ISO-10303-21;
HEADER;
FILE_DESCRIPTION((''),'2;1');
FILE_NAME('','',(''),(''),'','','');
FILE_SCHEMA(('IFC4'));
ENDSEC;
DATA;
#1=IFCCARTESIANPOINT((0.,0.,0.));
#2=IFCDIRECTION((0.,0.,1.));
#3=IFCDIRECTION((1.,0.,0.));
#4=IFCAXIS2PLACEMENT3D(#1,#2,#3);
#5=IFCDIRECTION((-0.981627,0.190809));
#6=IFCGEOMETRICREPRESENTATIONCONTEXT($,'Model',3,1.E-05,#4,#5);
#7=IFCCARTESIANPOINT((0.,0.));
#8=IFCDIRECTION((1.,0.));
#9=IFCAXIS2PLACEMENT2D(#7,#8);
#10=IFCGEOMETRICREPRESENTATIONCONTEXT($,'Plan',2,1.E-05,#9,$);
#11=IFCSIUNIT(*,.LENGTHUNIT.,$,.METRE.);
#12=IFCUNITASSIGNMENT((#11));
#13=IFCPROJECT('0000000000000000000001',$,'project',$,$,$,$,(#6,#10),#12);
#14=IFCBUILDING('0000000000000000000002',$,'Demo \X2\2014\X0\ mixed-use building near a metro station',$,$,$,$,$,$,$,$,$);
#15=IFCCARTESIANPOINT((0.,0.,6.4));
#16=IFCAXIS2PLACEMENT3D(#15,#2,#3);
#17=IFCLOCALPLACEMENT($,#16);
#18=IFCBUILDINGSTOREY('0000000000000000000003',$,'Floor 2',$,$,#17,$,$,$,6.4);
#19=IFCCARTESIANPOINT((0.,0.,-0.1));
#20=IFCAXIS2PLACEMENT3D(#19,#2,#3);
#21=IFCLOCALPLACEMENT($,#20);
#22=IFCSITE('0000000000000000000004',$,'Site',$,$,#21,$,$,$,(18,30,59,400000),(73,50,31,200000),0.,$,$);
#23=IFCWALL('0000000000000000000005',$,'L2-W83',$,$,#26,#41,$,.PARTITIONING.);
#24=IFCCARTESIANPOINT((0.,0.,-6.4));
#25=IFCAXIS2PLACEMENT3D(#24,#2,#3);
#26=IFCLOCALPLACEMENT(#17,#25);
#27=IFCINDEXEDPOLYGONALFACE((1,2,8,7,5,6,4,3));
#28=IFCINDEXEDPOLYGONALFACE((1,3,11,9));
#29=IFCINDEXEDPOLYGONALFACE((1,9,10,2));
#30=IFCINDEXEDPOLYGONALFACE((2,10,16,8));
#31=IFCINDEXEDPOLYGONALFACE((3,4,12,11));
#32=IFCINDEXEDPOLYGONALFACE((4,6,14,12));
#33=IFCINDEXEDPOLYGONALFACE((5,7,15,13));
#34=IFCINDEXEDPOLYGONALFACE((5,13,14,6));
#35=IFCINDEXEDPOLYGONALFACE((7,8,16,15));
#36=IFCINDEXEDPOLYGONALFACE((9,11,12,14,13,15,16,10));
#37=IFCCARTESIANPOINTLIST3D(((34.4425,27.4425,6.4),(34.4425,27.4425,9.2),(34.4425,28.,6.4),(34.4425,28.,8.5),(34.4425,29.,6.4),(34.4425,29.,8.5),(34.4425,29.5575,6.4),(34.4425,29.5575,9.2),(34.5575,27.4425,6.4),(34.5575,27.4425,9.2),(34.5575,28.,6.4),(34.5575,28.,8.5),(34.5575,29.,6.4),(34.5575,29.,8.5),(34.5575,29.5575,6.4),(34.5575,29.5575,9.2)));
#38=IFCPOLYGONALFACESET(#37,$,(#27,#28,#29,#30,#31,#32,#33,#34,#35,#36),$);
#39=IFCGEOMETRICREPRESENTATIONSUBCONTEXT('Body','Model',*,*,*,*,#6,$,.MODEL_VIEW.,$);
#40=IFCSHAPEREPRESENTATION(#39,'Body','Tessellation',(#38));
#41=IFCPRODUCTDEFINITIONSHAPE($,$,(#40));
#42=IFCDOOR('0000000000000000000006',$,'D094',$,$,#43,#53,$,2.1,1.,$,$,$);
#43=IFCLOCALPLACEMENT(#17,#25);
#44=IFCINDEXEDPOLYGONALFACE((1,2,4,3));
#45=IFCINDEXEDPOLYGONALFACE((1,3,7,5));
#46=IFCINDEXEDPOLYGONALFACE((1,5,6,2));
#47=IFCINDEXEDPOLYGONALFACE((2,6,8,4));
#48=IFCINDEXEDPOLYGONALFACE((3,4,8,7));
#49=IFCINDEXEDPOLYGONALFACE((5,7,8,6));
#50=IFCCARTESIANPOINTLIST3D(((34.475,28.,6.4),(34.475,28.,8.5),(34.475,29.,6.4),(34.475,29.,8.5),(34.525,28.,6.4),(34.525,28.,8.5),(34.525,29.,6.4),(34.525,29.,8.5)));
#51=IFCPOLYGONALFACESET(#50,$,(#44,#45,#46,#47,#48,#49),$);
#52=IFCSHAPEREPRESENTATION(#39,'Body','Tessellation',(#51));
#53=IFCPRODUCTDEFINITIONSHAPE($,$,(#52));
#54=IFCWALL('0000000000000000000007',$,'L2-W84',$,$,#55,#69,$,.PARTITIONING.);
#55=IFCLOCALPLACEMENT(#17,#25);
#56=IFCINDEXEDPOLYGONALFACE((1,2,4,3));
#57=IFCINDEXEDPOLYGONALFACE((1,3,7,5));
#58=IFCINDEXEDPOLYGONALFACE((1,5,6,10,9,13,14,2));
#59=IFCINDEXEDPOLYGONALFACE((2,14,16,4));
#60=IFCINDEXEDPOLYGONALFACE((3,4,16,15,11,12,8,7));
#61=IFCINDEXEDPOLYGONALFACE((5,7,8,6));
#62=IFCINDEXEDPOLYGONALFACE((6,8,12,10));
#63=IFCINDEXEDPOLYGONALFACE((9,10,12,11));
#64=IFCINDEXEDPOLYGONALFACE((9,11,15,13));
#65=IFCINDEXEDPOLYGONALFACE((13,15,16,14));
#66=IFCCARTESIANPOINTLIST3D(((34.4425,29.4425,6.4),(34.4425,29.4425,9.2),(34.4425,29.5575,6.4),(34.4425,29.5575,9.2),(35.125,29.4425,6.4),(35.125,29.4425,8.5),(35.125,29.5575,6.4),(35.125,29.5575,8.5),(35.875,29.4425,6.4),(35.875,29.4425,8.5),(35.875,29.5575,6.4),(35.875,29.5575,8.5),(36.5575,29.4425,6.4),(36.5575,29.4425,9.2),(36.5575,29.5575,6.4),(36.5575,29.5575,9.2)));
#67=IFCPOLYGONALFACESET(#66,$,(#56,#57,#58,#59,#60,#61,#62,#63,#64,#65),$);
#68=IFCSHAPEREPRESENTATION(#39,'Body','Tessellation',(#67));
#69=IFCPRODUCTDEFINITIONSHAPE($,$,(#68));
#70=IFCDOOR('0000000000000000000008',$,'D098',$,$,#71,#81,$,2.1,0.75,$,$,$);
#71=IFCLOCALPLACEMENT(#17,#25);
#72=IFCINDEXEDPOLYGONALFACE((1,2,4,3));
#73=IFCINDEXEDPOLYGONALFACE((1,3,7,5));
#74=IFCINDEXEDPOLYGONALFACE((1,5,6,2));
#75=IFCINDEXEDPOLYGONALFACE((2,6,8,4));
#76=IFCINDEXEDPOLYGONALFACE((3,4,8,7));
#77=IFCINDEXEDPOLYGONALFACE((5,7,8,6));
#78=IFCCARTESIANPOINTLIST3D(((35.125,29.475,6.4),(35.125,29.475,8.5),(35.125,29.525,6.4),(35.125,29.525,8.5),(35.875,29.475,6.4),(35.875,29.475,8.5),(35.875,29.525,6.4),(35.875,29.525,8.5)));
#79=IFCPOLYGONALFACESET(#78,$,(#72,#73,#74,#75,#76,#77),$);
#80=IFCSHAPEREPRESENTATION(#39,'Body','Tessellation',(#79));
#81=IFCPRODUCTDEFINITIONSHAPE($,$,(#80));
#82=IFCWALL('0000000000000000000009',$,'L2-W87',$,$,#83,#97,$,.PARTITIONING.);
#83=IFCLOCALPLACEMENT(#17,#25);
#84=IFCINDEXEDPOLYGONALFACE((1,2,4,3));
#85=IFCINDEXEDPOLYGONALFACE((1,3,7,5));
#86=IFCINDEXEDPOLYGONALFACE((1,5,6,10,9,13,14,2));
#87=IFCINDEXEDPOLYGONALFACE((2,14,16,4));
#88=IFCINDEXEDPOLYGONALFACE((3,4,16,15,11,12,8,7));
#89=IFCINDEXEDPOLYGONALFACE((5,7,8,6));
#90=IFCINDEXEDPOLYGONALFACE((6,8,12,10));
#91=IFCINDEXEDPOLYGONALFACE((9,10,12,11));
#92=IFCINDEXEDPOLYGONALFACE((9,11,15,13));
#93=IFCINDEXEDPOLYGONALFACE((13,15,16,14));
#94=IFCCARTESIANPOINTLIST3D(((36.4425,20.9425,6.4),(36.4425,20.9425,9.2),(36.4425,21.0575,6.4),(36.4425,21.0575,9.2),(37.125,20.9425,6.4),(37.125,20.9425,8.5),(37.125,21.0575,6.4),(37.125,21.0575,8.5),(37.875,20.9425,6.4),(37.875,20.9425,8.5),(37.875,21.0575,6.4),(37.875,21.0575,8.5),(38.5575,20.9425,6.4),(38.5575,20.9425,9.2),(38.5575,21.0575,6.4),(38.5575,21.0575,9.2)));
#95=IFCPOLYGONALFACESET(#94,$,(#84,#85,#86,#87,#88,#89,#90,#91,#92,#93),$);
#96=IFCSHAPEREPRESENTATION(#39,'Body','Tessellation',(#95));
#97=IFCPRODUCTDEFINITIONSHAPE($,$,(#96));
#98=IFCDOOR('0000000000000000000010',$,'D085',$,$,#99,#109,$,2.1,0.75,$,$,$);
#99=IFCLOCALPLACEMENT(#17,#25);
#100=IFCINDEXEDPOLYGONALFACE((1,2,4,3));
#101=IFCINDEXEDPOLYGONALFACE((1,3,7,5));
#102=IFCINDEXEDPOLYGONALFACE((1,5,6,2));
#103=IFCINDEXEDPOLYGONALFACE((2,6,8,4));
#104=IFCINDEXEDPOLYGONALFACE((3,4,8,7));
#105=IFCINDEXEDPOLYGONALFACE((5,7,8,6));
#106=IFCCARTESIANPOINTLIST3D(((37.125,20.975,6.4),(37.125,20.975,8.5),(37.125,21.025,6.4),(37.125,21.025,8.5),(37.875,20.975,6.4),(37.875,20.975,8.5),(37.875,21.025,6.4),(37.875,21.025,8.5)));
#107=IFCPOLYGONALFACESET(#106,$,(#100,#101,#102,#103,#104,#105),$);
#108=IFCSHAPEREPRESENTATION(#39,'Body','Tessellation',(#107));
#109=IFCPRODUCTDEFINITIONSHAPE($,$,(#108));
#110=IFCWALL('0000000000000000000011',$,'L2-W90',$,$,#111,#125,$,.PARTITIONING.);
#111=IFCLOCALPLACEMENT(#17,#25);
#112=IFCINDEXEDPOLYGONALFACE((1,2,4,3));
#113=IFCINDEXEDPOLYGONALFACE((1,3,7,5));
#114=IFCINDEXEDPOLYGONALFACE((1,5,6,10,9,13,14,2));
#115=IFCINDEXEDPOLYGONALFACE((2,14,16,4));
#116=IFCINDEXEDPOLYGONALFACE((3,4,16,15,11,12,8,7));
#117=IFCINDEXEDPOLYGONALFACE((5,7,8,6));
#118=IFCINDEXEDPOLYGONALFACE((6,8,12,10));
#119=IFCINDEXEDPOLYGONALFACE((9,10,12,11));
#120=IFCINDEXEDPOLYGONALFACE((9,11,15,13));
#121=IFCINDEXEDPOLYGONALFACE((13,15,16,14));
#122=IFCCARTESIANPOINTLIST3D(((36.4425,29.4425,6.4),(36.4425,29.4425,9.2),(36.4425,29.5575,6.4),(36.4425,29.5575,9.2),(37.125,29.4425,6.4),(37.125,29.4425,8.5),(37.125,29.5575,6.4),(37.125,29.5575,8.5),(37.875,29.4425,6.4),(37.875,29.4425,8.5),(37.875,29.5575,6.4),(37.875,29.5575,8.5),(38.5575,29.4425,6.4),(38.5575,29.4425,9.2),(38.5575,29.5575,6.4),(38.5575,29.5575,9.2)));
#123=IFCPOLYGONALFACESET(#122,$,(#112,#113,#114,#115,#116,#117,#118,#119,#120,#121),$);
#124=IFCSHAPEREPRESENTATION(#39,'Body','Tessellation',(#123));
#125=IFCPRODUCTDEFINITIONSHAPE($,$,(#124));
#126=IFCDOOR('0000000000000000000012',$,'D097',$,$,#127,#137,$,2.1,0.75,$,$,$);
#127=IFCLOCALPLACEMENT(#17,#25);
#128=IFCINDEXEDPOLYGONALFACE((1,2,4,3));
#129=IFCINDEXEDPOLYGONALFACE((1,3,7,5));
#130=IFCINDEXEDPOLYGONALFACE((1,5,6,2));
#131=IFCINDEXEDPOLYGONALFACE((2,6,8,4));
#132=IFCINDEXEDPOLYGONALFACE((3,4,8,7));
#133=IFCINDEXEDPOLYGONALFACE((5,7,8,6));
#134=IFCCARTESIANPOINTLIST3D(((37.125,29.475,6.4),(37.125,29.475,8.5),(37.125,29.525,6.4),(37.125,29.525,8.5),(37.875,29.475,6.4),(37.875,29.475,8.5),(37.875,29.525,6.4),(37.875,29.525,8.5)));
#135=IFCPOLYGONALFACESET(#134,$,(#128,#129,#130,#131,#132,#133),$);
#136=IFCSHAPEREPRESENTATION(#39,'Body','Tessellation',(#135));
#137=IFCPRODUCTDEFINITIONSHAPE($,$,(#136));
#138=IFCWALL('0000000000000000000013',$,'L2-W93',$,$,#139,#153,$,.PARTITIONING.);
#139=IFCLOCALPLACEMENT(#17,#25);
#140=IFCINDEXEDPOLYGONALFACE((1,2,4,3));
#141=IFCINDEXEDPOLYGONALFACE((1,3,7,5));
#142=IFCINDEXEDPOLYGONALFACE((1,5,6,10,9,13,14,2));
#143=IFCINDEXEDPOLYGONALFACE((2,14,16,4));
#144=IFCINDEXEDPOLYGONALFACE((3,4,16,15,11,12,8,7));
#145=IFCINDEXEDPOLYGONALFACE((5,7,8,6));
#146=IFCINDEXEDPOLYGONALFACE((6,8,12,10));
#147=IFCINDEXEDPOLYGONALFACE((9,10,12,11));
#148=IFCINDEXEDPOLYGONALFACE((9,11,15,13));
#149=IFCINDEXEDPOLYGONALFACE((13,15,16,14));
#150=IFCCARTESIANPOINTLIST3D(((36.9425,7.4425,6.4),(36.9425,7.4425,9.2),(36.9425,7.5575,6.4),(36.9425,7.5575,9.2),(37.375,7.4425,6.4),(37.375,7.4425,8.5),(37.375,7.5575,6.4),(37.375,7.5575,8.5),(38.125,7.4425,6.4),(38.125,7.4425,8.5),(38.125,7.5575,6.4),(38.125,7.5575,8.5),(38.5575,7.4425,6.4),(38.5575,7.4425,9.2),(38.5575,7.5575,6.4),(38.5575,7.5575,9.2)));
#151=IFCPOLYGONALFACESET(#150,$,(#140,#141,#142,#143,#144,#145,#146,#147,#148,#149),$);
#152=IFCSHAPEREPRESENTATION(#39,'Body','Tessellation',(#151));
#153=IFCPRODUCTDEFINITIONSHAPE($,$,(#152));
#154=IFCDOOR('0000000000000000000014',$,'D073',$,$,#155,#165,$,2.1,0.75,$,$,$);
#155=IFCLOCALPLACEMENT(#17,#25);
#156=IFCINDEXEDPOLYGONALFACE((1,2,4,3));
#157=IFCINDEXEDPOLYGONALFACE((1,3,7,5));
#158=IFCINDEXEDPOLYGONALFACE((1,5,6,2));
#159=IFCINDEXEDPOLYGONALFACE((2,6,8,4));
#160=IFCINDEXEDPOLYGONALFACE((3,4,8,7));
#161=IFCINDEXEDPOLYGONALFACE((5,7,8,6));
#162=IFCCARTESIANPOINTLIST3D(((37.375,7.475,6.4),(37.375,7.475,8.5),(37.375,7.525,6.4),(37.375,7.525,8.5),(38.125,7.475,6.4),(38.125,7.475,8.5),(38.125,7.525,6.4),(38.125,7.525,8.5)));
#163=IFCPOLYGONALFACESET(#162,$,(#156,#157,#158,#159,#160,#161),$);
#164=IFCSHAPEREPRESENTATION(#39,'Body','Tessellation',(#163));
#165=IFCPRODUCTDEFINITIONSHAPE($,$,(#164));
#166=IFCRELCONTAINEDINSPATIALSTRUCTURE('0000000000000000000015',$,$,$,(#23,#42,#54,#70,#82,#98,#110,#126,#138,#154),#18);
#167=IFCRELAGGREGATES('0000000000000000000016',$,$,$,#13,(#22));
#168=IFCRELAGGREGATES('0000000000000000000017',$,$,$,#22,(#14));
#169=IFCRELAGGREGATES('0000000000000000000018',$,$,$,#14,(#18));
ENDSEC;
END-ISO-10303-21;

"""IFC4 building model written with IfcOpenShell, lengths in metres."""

from ifc_helpers import new_model, si_unit, direction, frame, origin_with_axes, origin_2d_with_axis, place, context, subcontext, project, spatial, line, indexed_curve, outline, extrude, element, fill, save


model = new_model("IFC4")

# Units and contexts
model_context = context("Model", 3, precision=1e-05, world=origin_with_axes(), true_north=direction((-0.981627, 0.190809)))
plan_context = context("Plan", 2, precision=1e-05, world=origin_2d_with_axis())
body_context = subcontext(model_context, "Body", "Model", "MODEL_VIEW")
ifc_project = project(units=[si_unit("LENGTHUNIT", "METRE")], contexts=[model_context, plan_context])

# Site, building, storey
site_placement = place(None, frame((0.0, 0.0, -0.1), z_axis=(0.0, 0.0, 1.0), x_axis=(1.0, 0.0, 0.0)))
site = spatial("IfcSite", under=ifc_project, at=site_placement, Name="Site", RefLatitude=(18, 30, 59, 400000), RefLongitude=(73, 50, 31, 200000), RefElevation=0.0)
building = spatial("IfcBuilding", under=site, Name="Demo — mixed-use building near a metro station")
storey_placement = place(None, frame((0.0, 0.0, 6.4), z_axis=(0.0, 0.0, 1.0), x_axis=(1.0, 0.0, 0.0)))
storey = spatial("IfcBuildingStorey", under=building, at=storey_placement, Name="Floor 2", Elevation=6.4)

# Walls, openings, doors
wall_1_placement = place(storey_placement, frame((0.0, 0.0, -6.4), z_axis=(0.0, 0.0, 1.0), x_axis=(1.0, 0.0, 0.0)))
wall_1 = element("IfcWall", 1, at=wall_1_placement, inside=storey, Name="L2-W83", PredefinedType="PARTITIONING", context=body_context, shape_type="SweptSolid", body=[
    extrude(outline(indexed_curve([(34.4425, 27.4425), (34.4425, 29.5575), (34.5575, 29.5575), (34.5575, 27.4425)], segments=[line(1, 2, 3, 4, 1)])), frame((0.0, 0.0, 6.4), z_axis=(0.0, 0.0, 1.0), x_axis=(1.0, 0.0, 0.0)), (0.0, 0.0, 1.0), 2.8),
])
opening_1_placement = place(wall_1_placement, origin_with_axes())
opening_1 = element("IfcOpeningElement", 2, at=opening_1_placement, cuts=wall_1, context=body_context, shape_type="SweptSolid", body=[
    extrude(outline(indexed_curve([(34.3925, 28.0), (34.3925, 29.0), (34.6075, 29.0), (34.6075, 28.0)], segments=[line(1, 2, 3, 4, 1)])), frame((0.0, 0.0, 6.4), z_axis=(0.0, 0.0, 1.0), x_axis=(1.0, 0.0, 0.0)), (0.0, 0.0, 1.0), 2.1),
])
door_1_placement = place(storey_placement, frame((0.0, 0.0, -6.4), z_axis=(0.0, 0.0, 1.0), x_axis=(1.0, 0.0, 0.0)))
door_1 = element("IfcDoor", 3, at=door_1_placement, inside=storey, Name="D094", OverallHeight=2.1, OverallWidth=1.0, context=body_context, shape_type="SweptSolid", body=[
    extrude(outline(indexed_curve([(34.475, 28.0), (34.475, 29.0), (34.525, 29.0), (34.525, 28.0)], segments=[line(1, 2, 3, 4, 1)])), frame((0.0, 0.0, 6.4), z_axis=(0.0, 0.0, 1.0), x_axis=(1.0, 0.0, 0.0)), (0.0, 0.0, 1.0), 2.1),
])
fill(opening_1, door_1)
wall_2_placement = place(storey_placement, frame((0.0, 0.0, -6.4), z_axis=(0.0, 0.0, 1.0), x_axis=(1.0, 0.0, 0.0)))
wall_2 = element("IfcWall", 4, at=wall_2_placement, inside=storey, Name="L2-W84", PredefinedType="PARTITIONING", context=body_context, shape_type="SweptSolid", body=[
    extrude(outline(indexed_curve([(36.5575, 29.4425), (34.4425, 29.4425), (34.4425, 29.5575), (36.5575, 29.5575)], segments=[line(1, 2, 3, 4, 1)])), frame((0.0, 0.0, 6.4), z_axis=(0.0, 0.0, 1.0), x_axis=(1.0, 0.0, 0.0)), (0.0, 0.0, 1.0), 2.8),
])
opening_2_placement = place(wall_2_placement, origin_with_axes())
opening_2 = element("IfcOpeningElement", 5, at=opening_2_placement, cuts=wall_2, context=body_context, shape_type="SweptSolid", body=[
    extrude(outline(indexed_curve([(35.875, 29.3925), (35.125, 29.3925), (35.125, 29.6075), (35.875, 29.6075)], segments=[line(1, 2, 3, 4, 1)])), frame((0.0, 0.0, 6.4), z_axis=(0.0, 0.0, 1.0), x_axis=(1.0, 0.0, 0.0)), (0.0, 0.0, 1.0), 2.1),
])
door_2_placement = place(storey_placement, frame((0.0, 0.0, -6.4), z_axis=(0.0, 0.0, 1.0), x_axis=(1.0, 0.0, 0.0)))
door_2 = element("IfcDoor", 6, at=door_2_placement, inside=storey, Name="D098", OverallHeight=2.1, OverallWidth=0.75, context=body_context, shape_type="SweptSolid", body=[
    extrude(outline(indexed_curve([(35.875, 29.475), (35.125, 29.475), (35.125, 29.525), (35.875, 29.525)], segments=[line(1, 2, 3, 4, 1)])), frame((0.0, 0.0, 6.4), z_axis=(0.0, 0.0, 1.0), x_axis=(1.0, 0.0, 0.0)), (0.0, 0.0, 1.0), 2.1),
])
fill(opening_2, door_2)

# Wall, opening, door
wall_3_placement = place(storey_placement, frame((0.0, 0.0, -6.4), z_axis=(0.0, 0.0, 1.0), x_axis=(1.0, 0.0, 0.0)))
wall_3 = element("IfcWall", 7, at=wall_3_placement, inside=storey, Name="L2-W87", PredefinedType="PARTITIONING", context=body_context, shape_type="SweptSolid", body=[
    extrude(outline(indexed_curve([(38.5575, 20.9425), (36.4425, 20.9425), (36.4425, 21.0575), (38.5575, 21.0575)], segments=[line(1, 2, 3, 4, 1)])), frame((0.0, 0.0, 6.4), z_axis=(0.0, 0.0, 1.0), x_axis=(1.0, 0.0, 0.0)), (0.0, 0.0, 1.0), 2.8),
])
opening_3_placement = place(wall_3_placement, origin_with_axes())
opening_3 = element("IfcOpeningElement", 8, at=opening_3_placement, cuts=wall_3, context=body_context, shape_type="SweptSolid", body=[
    extrude(outline(indexed_curve([(37.875, 20.8925), (37.125, 20.8925), (37.125, 21.1075), (37.875, 21.1075)], segments=[line(1, 2, 3, 4, 1)])), frame((0.0, 0.0, 6.4), z_axis=(0.0, 0.0, 1.0), x_axis=(1.0, 0.0, 0.0)), (0.0, 0.0, 1.0), 2.1),
])
door_3_placement = place(storey_placement, frame((0.0, 0.0, -6.4), z_axis=(0.0, 0.0, 1.0), x_axis=(1.0, 0.0, 0.0)))
door_3 = element("IfcDoor", 9, at=door_3_placement, inside=storey, Name="D085", OverallHeight=2.1, OverallWidth=0.75, context=body_context, shape_type="SweptSolid", body=[
    extrude(outline(indexed_curve([(37.875, 20.975), (37.125, 20.975), (37.125, 21.025), (37.875, 21.025)], segments=[line(1, 2, 3, 4, 1)])), frame((0.0, 0.0, 6.4), z_axis=(0.0, 0.0, 1.0), x_axis=(1.0, 0.0, 0.0)), (0.0, 0.0, 1.0), 2.1),
])
fill(opening_3, door_3)

# Wall, opening, door
wall_4_placement = place(storey_placement, frame((0.0, 0.0, -6.4), z_axis=(0.0, 0.0, 1.0), x_axis=(1.0, 0.0, 0.0)))
wall_4 = element("IfcWall", 10, at=wall_4_placement, inside=storey, Name="L2-W90", PredefinedType="PARTITIONING", context=body_context, shape_type="SweptSolid", body=[
    extrude(outline(indexed_curve([(38.5575, 29.4425), (36.4425, 29.4425), (36.4425, 29.5575), (38.5575, 29.5575)], segments=[line(1, 2, 3, 4, 1)])), frame((0.0, 0.0, 6.4), z_axis=(0.0, 0.0, 1.0), x_axis=(1.0, 0.0, 0.0)), (0.0, 0.0, 1.0), 2.8),
])
opening_4_placement = place(wall_4_placement, origin_with_axes())
opening_4 = element("IfcOpeningElement", 11, at=opening_4_placement, cuts=wall_4, context=body_context, shape_type="SweptSolid", body=[
    extrude(outline(indexed_curve([(37.875, 29.3925), (37.125, 29.3925), (37.125, 29.6075), (37.875, 29.6075)], segments=[line(1, 2, 3, 4, 1)])), frame((0.0, 0.0, 6.4), z_axis=(0.0, 0.0, 1.0), x_axis=(1.0, 0.0, 0.0)), (0.0, 0.0, 1.0), 2.1),
])
door_4_placement = place(storey_placement, frame((0.0, 0.0, -6.4), z_axis=(0.0, 0.0, 1.0), x_axis=(1.0, 0.0, 0.0)))
door_4 = element("IfcDoor", 12, at=door_4_placement, inside=storey, Name="D097", OverallHeight=2.1, OverallWidth=0.75, context=body_context, shape_type="SweptSolid", body=[
    extrude(outline(indexed_curve([(37.875, 29.475), (37.125, 29.475), (37.125, 29.525), (37.875, 29.525)], segments=[line(1, 2, 3, 4, 1)])), frame((0.0, 0.0, 6.4), z_axis=(0.0, 0.0, 1.0), x_axis=(1.0, 0.0, 0.0)), (0.0, 0.0, 1.0), 2.1),
])
fill(opening_4, door_4)

# Wall, opening, door
wall_5_placement = place(storey_placement, frame((0.0, 0.0, -6.4), z_axis=(0.0, 0.0, 1.0), x_axis=(1.0, 0.0, 0.0)))
wall_5 = element("IfcWall", 13, at=wall_5_placement, inside=storey, Name="L2-W93", PredefinedType="PARTITIONING", context=body_context, shape_type="SweptSolid", body=[
    extrude(outline(indexed_curve([(38.5575, 7.4425), (36.9425, 7.4425), (36.9425, 7.5575), (38.5575, 7.5575)], segments=[line(1, 2, 3, 4, 1)])), frame((0.0, 0.0, 6.4), z_axis=(0.0, 0.0, 1.0), x_axis=(1.0, 0.0, 0.0)), (0.0, 0.0, 1.0), 2.8),
])
opening_5_placement = place(wall_5_placement, origin_with_axes())
opening_5 = element("IfcOpeningElement", 14, at=opening_5_placement, cuts=wall_5, context=body_context, shape_type="SweptSolid", body=[
    extrude(outline(indexed_curve([(38.125, 7.3925), (37.375, 7.3925), (37.375, 7.6075), (38.125, 7.6075)], segments=[line(1, 2, 3, 4, 1)])), frame((0.0, 0.0, 6.4), z_axis=(0.0, 0.0, 1.0), x_axis=(1.0, 0.0, 0.0)), (0.0, 0.0, 1.0), 2.1),
])
door_5_placement = place(storey_placement, frame((0.0, 0.0, -6.4), z_axis=(0.0, 0.0, 1.0), x_axis=(1.0, 0.0, 0.0)))
door_5 = element("IfcDoor", 15, at=door_5_placement, inside=storey, Name="D073", OverallHeight=2.1, OverallWidth=0.75, context=body_context, shape_type="SweptSolid", body=[
    extrude(outline(indexed_curve([(38.125, 7.475), (37.375, 7.475), (37.375, 7.525), (38.125, 7.525)], segments=[line(1, 2, 3, 4, 1)])), frame((0.0, 0.0, 6.4), z_axis=(0.0, 0.0, 1.0), x_axis=(1.0, 0.0, 0.0)), (0.0, 0.0, 1.0), 2.1),
])
fill(opening_5, door_5)

save(model, "model.ifc")
